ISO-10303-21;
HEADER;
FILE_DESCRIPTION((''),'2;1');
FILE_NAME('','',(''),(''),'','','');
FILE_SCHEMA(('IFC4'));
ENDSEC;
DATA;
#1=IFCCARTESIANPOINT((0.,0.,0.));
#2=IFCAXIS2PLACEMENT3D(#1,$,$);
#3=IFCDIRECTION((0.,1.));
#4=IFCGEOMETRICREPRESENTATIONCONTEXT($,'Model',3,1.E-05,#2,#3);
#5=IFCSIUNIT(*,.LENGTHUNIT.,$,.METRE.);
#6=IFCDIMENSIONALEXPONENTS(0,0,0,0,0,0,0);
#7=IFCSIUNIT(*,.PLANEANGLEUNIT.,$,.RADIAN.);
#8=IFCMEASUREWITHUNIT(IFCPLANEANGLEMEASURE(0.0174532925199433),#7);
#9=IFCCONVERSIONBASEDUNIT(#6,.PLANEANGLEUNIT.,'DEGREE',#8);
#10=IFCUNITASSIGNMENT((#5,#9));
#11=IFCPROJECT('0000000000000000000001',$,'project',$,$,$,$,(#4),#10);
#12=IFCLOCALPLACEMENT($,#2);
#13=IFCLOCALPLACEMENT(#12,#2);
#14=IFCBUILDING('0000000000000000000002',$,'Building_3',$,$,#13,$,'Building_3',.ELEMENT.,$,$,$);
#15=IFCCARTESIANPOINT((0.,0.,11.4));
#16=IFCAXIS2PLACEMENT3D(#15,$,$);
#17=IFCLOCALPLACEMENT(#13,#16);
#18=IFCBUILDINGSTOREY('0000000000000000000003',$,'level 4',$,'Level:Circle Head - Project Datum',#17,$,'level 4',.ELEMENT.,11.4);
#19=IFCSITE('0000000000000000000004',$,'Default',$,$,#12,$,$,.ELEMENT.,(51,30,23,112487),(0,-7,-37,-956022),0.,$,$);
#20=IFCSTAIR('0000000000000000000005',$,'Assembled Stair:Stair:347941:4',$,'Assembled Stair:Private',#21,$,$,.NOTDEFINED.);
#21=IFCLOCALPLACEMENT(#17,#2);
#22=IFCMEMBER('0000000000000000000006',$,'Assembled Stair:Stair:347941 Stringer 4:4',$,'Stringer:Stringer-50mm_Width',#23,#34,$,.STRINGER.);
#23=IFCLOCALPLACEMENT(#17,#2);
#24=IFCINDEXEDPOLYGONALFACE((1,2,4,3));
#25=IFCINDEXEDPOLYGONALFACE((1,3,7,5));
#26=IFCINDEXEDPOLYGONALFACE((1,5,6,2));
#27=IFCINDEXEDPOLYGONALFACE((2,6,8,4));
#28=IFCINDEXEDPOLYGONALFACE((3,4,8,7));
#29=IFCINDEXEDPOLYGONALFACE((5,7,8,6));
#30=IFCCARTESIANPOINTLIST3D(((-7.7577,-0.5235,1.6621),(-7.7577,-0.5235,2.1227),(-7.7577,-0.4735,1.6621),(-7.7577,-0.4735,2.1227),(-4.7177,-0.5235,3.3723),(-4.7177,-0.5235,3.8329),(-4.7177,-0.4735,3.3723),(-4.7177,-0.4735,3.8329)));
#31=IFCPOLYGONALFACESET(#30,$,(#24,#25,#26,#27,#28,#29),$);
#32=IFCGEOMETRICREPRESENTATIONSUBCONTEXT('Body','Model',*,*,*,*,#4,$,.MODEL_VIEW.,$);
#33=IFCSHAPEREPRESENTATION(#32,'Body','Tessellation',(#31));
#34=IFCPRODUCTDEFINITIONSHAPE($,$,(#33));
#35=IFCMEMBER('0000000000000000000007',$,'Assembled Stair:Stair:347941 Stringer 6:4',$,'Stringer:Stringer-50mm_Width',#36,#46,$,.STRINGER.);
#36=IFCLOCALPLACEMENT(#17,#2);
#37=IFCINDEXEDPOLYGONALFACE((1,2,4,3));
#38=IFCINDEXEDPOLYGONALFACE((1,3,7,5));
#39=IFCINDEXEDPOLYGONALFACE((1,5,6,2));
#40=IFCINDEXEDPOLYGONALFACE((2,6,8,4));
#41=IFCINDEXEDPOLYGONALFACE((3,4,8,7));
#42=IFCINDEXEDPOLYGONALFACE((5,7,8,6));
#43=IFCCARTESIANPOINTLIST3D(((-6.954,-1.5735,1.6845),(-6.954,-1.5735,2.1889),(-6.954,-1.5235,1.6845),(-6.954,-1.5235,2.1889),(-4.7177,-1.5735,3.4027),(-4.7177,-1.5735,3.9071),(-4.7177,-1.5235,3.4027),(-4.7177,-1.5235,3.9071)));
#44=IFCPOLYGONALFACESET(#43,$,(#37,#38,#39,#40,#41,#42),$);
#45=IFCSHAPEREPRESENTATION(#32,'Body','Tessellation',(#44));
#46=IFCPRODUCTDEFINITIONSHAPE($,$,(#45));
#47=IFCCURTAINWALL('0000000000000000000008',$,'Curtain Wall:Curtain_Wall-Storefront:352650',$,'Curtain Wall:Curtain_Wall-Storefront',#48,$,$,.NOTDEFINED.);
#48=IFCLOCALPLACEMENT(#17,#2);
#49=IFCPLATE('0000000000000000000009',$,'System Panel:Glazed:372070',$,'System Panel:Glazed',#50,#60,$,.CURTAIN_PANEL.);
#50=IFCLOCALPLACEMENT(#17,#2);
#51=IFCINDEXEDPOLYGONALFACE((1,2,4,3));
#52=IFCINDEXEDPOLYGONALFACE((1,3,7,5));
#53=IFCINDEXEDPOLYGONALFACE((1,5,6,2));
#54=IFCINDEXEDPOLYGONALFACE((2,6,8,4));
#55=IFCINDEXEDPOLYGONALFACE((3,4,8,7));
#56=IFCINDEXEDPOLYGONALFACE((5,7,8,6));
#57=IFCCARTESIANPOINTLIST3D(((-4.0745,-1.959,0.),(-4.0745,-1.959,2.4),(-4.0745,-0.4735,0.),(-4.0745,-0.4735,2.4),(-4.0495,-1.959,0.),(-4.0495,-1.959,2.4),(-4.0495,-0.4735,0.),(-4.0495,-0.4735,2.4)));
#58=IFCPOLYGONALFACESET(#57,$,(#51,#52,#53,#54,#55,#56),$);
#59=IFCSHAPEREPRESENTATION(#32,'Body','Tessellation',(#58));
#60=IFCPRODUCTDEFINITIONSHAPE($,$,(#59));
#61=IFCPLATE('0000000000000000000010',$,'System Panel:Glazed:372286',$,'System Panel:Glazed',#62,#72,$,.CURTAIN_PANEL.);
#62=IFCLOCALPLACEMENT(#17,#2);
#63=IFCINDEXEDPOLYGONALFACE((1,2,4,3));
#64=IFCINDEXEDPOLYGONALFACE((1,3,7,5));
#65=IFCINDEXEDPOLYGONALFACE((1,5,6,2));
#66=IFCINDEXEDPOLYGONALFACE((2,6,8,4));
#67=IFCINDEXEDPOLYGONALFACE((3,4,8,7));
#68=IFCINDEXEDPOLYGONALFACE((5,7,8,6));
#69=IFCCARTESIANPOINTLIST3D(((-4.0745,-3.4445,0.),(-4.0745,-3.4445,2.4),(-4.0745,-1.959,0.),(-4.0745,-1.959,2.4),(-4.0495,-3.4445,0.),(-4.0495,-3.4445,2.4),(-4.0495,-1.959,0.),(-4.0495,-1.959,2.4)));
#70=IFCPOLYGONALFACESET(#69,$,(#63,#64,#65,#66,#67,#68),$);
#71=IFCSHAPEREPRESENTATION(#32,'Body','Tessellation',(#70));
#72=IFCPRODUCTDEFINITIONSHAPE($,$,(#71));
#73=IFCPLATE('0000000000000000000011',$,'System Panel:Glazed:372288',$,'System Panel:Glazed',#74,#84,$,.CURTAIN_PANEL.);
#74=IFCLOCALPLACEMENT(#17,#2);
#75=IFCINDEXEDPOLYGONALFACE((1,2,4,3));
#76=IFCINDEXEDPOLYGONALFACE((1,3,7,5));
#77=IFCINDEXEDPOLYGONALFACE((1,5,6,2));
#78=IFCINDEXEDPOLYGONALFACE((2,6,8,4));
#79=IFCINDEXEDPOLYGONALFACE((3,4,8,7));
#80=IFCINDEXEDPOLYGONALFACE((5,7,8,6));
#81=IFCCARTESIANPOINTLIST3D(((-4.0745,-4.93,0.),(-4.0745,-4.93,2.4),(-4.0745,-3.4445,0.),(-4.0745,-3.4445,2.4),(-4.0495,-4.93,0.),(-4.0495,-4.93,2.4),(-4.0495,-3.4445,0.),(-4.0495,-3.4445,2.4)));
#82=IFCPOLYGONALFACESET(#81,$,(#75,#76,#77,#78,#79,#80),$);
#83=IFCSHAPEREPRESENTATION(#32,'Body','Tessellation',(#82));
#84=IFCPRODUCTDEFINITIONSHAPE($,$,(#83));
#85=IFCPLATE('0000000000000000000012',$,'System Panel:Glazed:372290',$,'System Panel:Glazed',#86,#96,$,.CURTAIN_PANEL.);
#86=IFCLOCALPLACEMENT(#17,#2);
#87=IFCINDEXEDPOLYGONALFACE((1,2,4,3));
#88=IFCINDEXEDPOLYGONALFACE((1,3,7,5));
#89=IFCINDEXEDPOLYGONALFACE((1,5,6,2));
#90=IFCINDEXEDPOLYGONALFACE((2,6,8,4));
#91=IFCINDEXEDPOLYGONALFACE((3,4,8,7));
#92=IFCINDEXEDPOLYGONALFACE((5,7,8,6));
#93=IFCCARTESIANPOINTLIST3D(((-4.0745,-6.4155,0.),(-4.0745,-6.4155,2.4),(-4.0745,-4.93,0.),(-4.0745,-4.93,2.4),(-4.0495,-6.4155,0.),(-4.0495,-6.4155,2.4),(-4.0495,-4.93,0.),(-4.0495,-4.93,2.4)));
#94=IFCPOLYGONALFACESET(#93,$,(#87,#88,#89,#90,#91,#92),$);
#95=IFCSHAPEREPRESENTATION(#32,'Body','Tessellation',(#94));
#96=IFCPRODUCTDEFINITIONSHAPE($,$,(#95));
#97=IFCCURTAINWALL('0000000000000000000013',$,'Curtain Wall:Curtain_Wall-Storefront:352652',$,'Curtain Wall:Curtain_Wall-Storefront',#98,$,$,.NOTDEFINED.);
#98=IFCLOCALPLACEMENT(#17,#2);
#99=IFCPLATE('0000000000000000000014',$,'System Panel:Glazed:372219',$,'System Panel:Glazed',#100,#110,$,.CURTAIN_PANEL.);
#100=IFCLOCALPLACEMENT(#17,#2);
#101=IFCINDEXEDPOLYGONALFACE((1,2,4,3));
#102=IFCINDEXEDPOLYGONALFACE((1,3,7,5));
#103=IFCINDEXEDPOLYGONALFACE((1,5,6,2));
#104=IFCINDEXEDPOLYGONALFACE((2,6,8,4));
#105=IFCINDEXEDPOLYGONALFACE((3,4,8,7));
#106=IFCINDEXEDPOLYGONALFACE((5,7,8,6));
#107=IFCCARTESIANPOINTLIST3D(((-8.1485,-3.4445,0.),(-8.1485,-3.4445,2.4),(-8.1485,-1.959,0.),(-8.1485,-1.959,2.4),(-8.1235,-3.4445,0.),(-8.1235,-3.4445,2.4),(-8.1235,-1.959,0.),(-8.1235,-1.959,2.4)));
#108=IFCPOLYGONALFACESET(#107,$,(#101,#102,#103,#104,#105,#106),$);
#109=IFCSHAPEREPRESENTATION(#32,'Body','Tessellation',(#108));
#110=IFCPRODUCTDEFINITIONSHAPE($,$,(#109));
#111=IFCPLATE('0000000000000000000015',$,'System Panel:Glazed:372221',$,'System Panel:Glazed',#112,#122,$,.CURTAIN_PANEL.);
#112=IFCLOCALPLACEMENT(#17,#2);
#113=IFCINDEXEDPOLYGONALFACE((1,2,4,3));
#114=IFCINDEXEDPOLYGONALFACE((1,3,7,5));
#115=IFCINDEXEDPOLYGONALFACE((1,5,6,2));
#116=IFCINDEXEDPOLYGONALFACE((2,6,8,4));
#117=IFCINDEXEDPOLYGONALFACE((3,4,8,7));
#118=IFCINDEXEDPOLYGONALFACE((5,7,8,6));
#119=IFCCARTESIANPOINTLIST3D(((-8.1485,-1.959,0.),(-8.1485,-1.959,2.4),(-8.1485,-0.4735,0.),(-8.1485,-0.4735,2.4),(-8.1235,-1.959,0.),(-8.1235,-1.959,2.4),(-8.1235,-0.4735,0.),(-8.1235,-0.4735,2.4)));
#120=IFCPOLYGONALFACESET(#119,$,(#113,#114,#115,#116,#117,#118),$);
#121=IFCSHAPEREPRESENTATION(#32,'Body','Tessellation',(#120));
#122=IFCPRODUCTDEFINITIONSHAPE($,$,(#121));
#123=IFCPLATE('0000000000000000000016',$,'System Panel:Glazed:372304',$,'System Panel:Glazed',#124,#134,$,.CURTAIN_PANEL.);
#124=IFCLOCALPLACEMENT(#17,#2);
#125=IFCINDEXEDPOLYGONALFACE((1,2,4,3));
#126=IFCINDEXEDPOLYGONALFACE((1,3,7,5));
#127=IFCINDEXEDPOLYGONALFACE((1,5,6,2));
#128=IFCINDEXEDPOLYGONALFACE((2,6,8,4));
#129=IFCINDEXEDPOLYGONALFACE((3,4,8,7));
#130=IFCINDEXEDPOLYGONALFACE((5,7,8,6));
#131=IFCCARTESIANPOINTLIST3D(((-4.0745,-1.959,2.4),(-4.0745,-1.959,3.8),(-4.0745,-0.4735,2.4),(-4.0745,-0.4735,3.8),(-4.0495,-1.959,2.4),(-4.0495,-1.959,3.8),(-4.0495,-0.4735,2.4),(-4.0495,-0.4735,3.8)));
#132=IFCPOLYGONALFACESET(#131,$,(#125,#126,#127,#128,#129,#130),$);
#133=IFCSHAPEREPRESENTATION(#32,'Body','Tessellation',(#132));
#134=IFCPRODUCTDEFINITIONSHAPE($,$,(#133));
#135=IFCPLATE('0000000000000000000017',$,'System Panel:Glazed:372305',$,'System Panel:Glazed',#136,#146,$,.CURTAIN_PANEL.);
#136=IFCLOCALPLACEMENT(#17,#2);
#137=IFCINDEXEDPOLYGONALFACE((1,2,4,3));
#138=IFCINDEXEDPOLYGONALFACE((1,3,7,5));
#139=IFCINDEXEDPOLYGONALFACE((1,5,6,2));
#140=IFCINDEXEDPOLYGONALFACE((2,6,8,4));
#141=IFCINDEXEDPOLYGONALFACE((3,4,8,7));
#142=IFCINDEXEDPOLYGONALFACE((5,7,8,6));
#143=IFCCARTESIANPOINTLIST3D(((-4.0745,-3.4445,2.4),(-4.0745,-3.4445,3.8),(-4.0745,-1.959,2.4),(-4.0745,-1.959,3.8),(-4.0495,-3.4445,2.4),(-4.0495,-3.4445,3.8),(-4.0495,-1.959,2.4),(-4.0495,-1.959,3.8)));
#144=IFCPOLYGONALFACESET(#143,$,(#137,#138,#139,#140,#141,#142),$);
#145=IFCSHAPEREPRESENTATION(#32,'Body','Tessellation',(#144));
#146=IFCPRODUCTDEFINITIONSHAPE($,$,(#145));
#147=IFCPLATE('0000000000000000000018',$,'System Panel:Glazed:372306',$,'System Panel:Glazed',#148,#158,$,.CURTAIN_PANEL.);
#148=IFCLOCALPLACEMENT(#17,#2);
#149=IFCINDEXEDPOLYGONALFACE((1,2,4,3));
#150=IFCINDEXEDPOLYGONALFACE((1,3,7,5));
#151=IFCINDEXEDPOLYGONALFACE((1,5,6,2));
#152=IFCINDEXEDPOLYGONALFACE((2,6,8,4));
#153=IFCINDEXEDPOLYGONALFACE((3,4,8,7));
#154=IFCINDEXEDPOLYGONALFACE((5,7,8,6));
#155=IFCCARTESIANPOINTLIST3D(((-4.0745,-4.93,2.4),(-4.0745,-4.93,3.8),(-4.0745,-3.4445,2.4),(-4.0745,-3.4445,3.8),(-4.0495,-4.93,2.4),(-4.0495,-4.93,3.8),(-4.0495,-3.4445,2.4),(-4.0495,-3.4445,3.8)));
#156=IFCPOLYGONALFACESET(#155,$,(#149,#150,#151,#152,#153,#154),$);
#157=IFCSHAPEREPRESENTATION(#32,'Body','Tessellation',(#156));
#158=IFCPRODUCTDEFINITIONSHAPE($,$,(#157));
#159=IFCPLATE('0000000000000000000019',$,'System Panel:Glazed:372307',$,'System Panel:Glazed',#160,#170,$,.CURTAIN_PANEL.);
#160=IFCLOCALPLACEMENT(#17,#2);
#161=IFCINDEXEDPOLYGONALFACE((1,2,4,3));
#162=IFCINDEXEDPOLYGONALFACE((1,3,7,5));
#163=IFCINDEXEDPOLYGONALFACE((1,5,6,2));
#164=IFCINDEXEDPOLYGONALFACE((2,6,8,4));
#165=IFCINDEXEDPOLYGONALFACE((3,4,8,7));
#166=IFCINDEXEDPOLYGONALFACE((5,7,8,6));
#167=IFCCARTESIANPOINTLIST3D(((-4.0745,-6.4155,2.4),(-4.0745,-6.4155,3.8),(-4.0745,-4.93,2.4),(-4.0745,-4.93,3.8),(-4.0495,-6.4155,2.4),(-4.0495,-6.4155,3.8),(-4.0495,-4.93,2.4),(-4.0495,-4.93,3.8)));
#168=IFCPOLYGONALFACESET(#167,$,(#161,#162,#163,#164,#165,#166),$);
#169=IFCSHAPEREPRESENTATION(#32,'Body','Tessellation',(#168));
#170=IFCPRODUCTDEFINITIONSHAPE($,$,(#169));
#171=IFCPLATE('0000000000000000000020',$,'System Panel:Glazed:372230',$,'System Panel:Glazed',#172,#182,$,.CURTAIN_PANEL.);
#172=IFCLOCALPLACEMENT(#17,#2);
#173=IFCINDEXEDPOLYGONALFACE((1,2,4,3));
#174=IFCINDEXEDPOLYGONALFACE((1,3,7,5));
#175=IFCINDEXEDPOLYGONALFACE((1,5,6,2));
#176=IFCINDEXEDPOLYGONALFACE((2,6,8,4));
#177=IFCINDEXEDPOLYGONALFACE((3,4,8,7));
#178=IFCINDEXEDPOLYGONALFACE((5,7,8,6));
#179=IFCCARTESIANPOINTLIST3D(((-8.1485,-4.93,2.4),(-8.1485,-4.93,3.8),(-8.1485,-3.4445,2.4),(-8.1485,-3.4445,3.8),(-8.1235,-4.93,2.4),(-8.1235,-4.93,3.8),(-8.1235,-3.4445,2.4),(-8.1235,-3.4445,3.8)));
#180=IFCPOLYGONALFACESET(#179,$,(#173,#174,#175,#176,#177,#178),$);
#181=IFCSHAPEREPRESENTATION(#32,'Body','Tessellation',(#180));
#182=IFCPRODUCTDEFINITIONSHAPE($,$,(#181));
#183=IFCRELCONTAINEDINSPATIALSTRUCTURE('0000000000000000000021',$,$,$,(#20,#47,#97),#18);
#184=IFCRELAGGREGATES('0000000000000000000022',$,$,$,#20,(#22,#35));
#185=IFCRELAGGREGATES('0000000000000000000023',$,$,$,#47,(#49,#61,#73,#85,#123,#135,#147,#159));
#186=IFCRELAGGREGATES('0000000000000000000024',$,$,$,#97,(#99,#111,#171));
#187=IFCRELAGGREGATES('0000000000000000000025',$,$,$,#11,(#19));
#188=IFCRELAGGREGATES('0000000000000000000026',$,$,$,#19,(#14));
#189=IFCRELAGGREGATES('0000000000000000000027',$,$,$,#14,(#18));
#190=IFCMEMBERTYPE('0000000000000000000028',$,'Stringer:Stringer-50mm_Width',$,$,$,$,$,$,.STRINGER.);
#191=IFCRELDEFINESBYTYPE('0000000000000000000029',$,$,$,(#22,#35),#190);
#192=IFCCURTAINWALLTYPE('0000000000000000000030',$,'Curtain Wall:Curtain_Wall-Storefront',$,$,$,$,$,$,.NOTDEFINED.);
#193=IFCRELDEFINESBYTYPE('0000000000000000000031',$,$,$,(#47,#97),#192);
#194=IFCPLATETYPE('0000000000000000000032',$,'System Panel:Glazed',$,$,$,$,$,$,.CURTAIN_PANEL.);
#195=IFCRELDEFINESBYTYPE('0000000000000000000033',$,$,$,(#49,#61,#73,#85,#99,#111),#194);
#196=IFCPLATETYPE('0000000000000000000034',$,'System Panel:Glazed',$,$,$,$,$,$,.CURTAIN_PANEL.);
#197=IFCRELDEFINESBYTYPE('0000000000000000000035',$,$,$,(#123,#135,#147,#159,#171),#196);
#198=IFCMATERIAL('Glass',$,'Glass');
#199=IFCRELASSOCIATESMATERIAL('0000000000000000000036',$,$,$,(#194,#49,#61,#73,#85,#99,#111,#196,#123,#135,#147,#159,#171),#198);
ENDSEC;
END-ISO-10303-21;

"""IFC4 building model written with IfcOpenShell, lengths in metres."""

from ifc_helpers import new_model, entity, si_unit, converted_unit, direction, frame, origin, origin_2d_with_axis, place, context, subcontext, project, spatial, polyline, rectangle, outline, extrude, source, transform, mapped, material, type_object, type_shapes, element, aggregate, save


model = new_model("IFC4")

# Units and contexts
model_context = context("Model", 3, precision=1e-05, world=origin(), true_north=direction((0.0, 1.0)))
body_context = subcontext(model_context, "Body", "Model", "MODEL_VIEW")
ifc_project = project(units=[si_unit("LENGTHUNIT", "METRE"), converted_unit("PLANEANGLEUNIT", "DEGREE", entity("IfcPlaneAngleMeasure", 0.0174532925199433), si_unit("PLANEANGLEUNIT", "RADIAN"), dimensions=[0, 0, 0, 0, 0, 0, 0])], contexts=[model_context])

# Site, building, storey
site_placement = place(None, origin())
site = spatial("IfcSite", under=ifc_project, at=site_placement, Name="Default", CompositionType="ELEMENT", RefLatitude=(51, 30, 23, 112487), RefLongitude=(0, -7, -37, -956022), RefElevation=0.0)
building_placement = place(site_placement, origin())
building = spatial("IfcBuilding", under=site, at=building_placement, Name="Building_3", LongName="Building_3", CompositionType="ELEMENT")
storey_placement = place(building_placement, frame((0.0, 0.0, 11.4)))
storey = spatial("IfcBuildingStorey", under=building, at=storey_placement, Name="level 4", ObjectType="Level:Circle Head - Project Datum", LongName="level 4", CompositionType="ELEMENT", Elevation=11.4)

# Stair, members
stair_placement = place(storey_placement, origin())
stair = element("IfcStair", 1, at=stair_placement, inside=storey, Name="Assembled Stair:Stair:347941:4", ObjectType="Assembled Stair:Private", PredefinedType="NOTDEFINED")
member_type = type_object("IfcMemberType", Name="Stringer:Stringer-50mm_Width", PredefinedType="STRINGER")
member_1_placement = place(stair_placement, frame((-7.7577, -0.5235, 1.6621)))
member_1 = element("IfcMember", 2, at=member_1_placement, type_object=member_type, Name="Assembled Stair:Stair:347941 Stringer 4:4", ObjectType="Stringer:Stringer-50mm_Width", PredefinedType="STRINGER", context=body_context, shape_type="SweptSolid", body=[
    extrude(outline(polyline([(-1.6311, -0.2007), (1.857, -0.2007), (1.6311, 0.2007), (-1.857, 0.2007), (-1.6311, -0.2007)])), frame((1.52, 0.0, 1.0854), z_axis=(0.0, 1.0, 0.0), x_axis=(0.871553, 0.0, 0.490302)), (0.0, 0.0, 1.0), 0.05),
])
member_2_placement = place(stair_placement, frame((-6.954, -1.5735, 1.6845)))
member_2 = element("IfcMember", 3, at=member_2_placement, type_object=member_type, Name="Assembled Stair:Stair:347941 Stringer 6:4", ObjectType="Stringer:Stringer-50mm_Width", PredefinedType="STRINGER", context=body_context, shape_type="SweptSolid", body=[
    extrude(outline(polyline([(-1.2564, -0.2), (1.5637, -0.2), (1.2564, 0.2), (-1.5637, 0.2), (-1.2564, -0.2)])), frame((1.1182, 0.0, 1.1113), z_axis=(0.0, 1.0, 0.0), x_axis=(0.792984, 0.0, 0.609242)), (0.0, 0.0, 1.0), 0.05),
])
aggregate(stair, [member_1, member_2])

# Curtain walls, plates
curtain_wall_type = type_object("IfcCurtainWallType", Name="Curtain Wall:Curtain_Wall-Storefront", PredefinedType="NOTDEFINED")
curtain_wall_1_placement = place(storey_placement, frame((0.0, 0.0, -11.4)))
curtain_wall_1 = element("IfcCurtainWall", 4, at=curtain_wall_1_placement, inside=storey, type_object=curtain_wall_type, Name="Curtain Wall:Curtain_Wall-Storefront:352650", ObjectType="Curtain Wall:Curtain_Wall-Storefront", PredefinedType="NOTDEFINED")
ifc_material_1 = material(Name="Glass", Category="Glass")
plate_type_1 = type_object("IfcPlateType", Name="System Panel:Glazed", PredefinedType="CURTAIN_PANEL", material=ifc_material_1)
shared_shape_1 = source(origin(), body_context, "Body", "SweptSolid", [
    extrude(rectangle(XDim=0.025, YDim=1.4855, at=origin_2d_with_axis()), frame((0.7428, 0.0125, 0.0), z_axis=(0.0, 0.0, 1.0), x_axis=(0.0, 1.0, 0.0)), (0.0, 0.0, 1.0), 2.4),
])
type_shapes(plate_type_1, [shared_shape_1])
plate_1_placement = place(curtain_wall_1_placement, frame((-4.0745, -0.4735, 11.4), z_axis=(0.0, 0.0, 1.0), x_axis=(0.0, -1.0, 0.0)))
plate_1 = element("IfcPlate", 5, at=plate_1_placement, type_object=plate_type_1, material=ifc_material_1, Name="System Panel:Glazed:372070", ObjectType="System Panel:Glazed", PredefinedType="CURTAIN_PANEL", context=body_context, shape_type="MappedRepresentation", body=[
    mapped(shared_shape_1, transform((0.0, 0.0, 0.0), scale=1.0)),
])
plate_2_placement = place(curtain_wall_1_placement, frame((-4.0745, -1.959, 11.4), z_axis=(0.0, 0.0, 1.0), x_axis=(0.0, -1.0, 0.0)))
plate_2 = element("IfcPlate", 6, at=plate_2_placement, type_object=plate_type_1, material=ifc_material_1, Name="System Panel:Glazed:372286", ObjectType="System Panel:Glazed", PredefinedType="CURTAIN_PANEL", context=body_context, shape_type="MappedRepresentation", body=[
    mapped(shared_shape_1, transform((0.0, 0.0, 0.0), scale=1.0)),
])
plate_3_placement = place(curtain_wall_1_placement, frame((-4.0745, -3.4445, 11.4), z_axis=(0.0, 0.0, 1.0), x_axis=(0.0, -1.0, 0.0)))
plate_3 = element("IfcPlate", 7, at=plate_3_placement, type_object=plate_type_1, material=ifc_material_1, Name="System Panel:Glazed:372288", ObjectType="System Panel:Glazed", PredefinedType="CURTAIN_PANEL", context=body_context, shape_type="MappedRepresentation", body=[
    mapped(shared_shape_1, transform((0.0, 0.0, 0.0), scale=1.0)),
])
plate_4_placement = place(curtain_wall_1_placement, frame((-4.0745, -4.93, 11.4), z_axis=(0.0, 0.0, 1.0), x_axis=(0.0, -1.0, 0.0)))
plate_4 = element("IfcPlate", 8, at=plate_4_placement, type_object=plate_type_1, material=ifc_material_1, Name="System Panel:Glazed:372290", ObjectType="System Panel:Glazed", PredefinedType="CURTAIN_PANEL", context=body_context, shape_type="MappedRepresentation", body=[
    mapped(shared_shape_1, transform((0.0, 0.0, 0.0), scale=1.0)),
])
curtain_wall_2_placement = place(storey_placement, frame((0.0, 0.0, -11.4)))
curtain_wall_2 = element("IfcCurtainWall", 9, at=curtain_wall_2_placement, inside=storey, type_object=curtain_wall_type, Name="Curtain Wall:Curtain_Wall-Storefront:352652", ObjectType="Curtain Wall:Curtain_Wall-Storefront", PredefinedType="NOTDEFINED")
plate_5_placement = place(curtain_wall_2_placement, frame((-8.1235, -3.4445, 11.4), z_axis=(0.0, 0.0, 1.0), x_axis=(0.0, 1.0, 0.0)))
plate_5 = element("IfcPlate", 10, at=plate_5_placement, type_object=plate_type_1, material=ifc_material_1, Name="System Panel:Glazed:372219", ObjectType="System Panel:Glazed", PredefinedType="CURTAIN_PANEL", context=body_context, shape_type="MappedRepresentation", body=[
    mapped(shared_shape_1, transform((0.0, 0.0, 0.0), scale=1.0)),
])
plate_6_placement = place(curtain_wall_2_placement, frame((-8.1235, -1.959, 11.4), z_axis=(0.0, 0.0, 1.0), x_axis=(0.0, 1.0, 0.0)))
plate_6 = element("IfcPlate", 11, at=plate_6_placement, type_object=plate_type_1, material=ifc_material_1, Name="System Panel:Glazed:372221", ObjectType="System Panel:Glazed", PredefinedType="CURTAIN_PANEL", context=body_context, shape_type="MappedRepresentation", body=[
    mapped(shared_shape_1, transform((0.0, 0.0, 0.0), scale=1.0)),
])

# Plates
plate_type_2 = type_object("IfcPlateType", Name="System Panel:Glazed", PredefinedType="CURTAIN_PANEL", material=ifc_material_1)
shared_shape_2 = source(origin(), body_context, "Body", "SweptSolid", [
    extrude(rectangle(XDim=0.025, YDim=1.4855, at=origin_2d_with_axis()), frame((0.7428, 0.0125, 0.0), z_axis=(0.0, 0.0, 1.0), x_axis=(0.0, 1.0, 0.0)), (0.0, 0.0, 1.0), 1.4),
])
type_shapes(plate_type_2, [shared_shape_2])
plate_7_placement = place(curtain_wall_1_placement, frame((-4.0745, -0.4735, 13.8), z_axis=(0.0, 0.0, 1.0), x_axis=(0.0, -1.0, 0.0)))
plate_7 = element("IfcPlate", 12, at=plate_7_placement, type_object=plate_type_2, material=ifc_material_1, Name="System Panel:Glazed:372304", ObjectType="System Panel:Glazed", PredefinedType="CURTAIN_PANEL", context=body_context, shape_type="MappedRepresentation", body=[
    mapped(shared_shape_2, transform((0.0, 0.0, 0.0), scale=1.0)),
])
plate_8_placement = place(curtain_wall_1_placement, frame((-4.0745, -1.959, 13.8), z_axis=(0.0, 0.0, 1.0), x_axis=(0.0, -1.0, 0.0)))
plate_8 = element("IfcPlate", 13, at=plate_8_placement, type_object=plate_type_2, material=ifc_material_1, Name="System Panel:Glazed:372305", ObjectType="System Panel:Glazed", PredefinedType="CURTAIN_PANEL", context=body_context, shape_type="MappedRepresentation", body=[
    mapped(shared_shape_2, transform((0.0, 0.0, 0.0), scale=1.0)),
])
plate_9_placement = place(curtain_wall_1_placement, frame((-4.0745, -3.4445, 13.8), z_axis=(0.0, 0.0, 1.0), x_axis=(0.0, -1.0, 0.0)))
plate_9 = element("IfcPlate", 14, at=plate_9_placement, type_object=plate_type_2, material=ifc_material_1, Name="System Panel:Glazed:372306", ObjectType="System Panel:Glazed", PredefinedType="CURTAIN_PANEL", context=body_context, shape_type="MappedRepresentation", body=[
    mapped(shared_shape_2, transform((0.0, 0.0, 0.0), scale=1.0)),
])
plate_10_placement = place(curtain_wall_1_placement, frame((-4.0745, -4.93, 13.8), z_axis=(0.0, 0.0, 1.0), x_axis=(0.0, -1.0, 0.0)))
plate_10 = element("IfcPlate", 15, at=plate_10_placement, type_object=plate_type_2, material=ifc_material_1, Name="System Panel:Glazed:372307", ObjectType="System Panel:Glazed", PredefinedType="CURTAIN_PANEL", context=body_context, shape_type="MappedRepresentation", body=[
    mapped(shared_shape_2, transform((0.0, 0.0, 0.0), scale=1.0)),
])
aggregate(curtain_wall_1, [plate_1, plate_2, plate_3, plate_4, plate_7, plate_8, plate_9, plate_10])
plate_11_placement = place(curtain_wall_2_placement, frame((-8.1235, -4.93, 13.8), z_axis=(0.0, 0.0, 1.0), x_axis=(0.0, 1.0, 0.0)))
plate_11 = element("IfcPlate", 16, at=plate_11_placement, type_object=plate_type_2, material=ifc_material_1, Name="System Panel:Glazed:372230", ObjectType="System Panel:Glazed", PredefinedType="CURTAIN_PANEL", context=body_context, shape_type="MappedRepresentation", body=[
    mapped(shared_shape_2, transform((0.0, 0.0, 0.0), scale=1.0)),
])
aggregate(curtain_wall_2, [plate_5, plate_6, plate_11])

save(model, "model.ifc")
